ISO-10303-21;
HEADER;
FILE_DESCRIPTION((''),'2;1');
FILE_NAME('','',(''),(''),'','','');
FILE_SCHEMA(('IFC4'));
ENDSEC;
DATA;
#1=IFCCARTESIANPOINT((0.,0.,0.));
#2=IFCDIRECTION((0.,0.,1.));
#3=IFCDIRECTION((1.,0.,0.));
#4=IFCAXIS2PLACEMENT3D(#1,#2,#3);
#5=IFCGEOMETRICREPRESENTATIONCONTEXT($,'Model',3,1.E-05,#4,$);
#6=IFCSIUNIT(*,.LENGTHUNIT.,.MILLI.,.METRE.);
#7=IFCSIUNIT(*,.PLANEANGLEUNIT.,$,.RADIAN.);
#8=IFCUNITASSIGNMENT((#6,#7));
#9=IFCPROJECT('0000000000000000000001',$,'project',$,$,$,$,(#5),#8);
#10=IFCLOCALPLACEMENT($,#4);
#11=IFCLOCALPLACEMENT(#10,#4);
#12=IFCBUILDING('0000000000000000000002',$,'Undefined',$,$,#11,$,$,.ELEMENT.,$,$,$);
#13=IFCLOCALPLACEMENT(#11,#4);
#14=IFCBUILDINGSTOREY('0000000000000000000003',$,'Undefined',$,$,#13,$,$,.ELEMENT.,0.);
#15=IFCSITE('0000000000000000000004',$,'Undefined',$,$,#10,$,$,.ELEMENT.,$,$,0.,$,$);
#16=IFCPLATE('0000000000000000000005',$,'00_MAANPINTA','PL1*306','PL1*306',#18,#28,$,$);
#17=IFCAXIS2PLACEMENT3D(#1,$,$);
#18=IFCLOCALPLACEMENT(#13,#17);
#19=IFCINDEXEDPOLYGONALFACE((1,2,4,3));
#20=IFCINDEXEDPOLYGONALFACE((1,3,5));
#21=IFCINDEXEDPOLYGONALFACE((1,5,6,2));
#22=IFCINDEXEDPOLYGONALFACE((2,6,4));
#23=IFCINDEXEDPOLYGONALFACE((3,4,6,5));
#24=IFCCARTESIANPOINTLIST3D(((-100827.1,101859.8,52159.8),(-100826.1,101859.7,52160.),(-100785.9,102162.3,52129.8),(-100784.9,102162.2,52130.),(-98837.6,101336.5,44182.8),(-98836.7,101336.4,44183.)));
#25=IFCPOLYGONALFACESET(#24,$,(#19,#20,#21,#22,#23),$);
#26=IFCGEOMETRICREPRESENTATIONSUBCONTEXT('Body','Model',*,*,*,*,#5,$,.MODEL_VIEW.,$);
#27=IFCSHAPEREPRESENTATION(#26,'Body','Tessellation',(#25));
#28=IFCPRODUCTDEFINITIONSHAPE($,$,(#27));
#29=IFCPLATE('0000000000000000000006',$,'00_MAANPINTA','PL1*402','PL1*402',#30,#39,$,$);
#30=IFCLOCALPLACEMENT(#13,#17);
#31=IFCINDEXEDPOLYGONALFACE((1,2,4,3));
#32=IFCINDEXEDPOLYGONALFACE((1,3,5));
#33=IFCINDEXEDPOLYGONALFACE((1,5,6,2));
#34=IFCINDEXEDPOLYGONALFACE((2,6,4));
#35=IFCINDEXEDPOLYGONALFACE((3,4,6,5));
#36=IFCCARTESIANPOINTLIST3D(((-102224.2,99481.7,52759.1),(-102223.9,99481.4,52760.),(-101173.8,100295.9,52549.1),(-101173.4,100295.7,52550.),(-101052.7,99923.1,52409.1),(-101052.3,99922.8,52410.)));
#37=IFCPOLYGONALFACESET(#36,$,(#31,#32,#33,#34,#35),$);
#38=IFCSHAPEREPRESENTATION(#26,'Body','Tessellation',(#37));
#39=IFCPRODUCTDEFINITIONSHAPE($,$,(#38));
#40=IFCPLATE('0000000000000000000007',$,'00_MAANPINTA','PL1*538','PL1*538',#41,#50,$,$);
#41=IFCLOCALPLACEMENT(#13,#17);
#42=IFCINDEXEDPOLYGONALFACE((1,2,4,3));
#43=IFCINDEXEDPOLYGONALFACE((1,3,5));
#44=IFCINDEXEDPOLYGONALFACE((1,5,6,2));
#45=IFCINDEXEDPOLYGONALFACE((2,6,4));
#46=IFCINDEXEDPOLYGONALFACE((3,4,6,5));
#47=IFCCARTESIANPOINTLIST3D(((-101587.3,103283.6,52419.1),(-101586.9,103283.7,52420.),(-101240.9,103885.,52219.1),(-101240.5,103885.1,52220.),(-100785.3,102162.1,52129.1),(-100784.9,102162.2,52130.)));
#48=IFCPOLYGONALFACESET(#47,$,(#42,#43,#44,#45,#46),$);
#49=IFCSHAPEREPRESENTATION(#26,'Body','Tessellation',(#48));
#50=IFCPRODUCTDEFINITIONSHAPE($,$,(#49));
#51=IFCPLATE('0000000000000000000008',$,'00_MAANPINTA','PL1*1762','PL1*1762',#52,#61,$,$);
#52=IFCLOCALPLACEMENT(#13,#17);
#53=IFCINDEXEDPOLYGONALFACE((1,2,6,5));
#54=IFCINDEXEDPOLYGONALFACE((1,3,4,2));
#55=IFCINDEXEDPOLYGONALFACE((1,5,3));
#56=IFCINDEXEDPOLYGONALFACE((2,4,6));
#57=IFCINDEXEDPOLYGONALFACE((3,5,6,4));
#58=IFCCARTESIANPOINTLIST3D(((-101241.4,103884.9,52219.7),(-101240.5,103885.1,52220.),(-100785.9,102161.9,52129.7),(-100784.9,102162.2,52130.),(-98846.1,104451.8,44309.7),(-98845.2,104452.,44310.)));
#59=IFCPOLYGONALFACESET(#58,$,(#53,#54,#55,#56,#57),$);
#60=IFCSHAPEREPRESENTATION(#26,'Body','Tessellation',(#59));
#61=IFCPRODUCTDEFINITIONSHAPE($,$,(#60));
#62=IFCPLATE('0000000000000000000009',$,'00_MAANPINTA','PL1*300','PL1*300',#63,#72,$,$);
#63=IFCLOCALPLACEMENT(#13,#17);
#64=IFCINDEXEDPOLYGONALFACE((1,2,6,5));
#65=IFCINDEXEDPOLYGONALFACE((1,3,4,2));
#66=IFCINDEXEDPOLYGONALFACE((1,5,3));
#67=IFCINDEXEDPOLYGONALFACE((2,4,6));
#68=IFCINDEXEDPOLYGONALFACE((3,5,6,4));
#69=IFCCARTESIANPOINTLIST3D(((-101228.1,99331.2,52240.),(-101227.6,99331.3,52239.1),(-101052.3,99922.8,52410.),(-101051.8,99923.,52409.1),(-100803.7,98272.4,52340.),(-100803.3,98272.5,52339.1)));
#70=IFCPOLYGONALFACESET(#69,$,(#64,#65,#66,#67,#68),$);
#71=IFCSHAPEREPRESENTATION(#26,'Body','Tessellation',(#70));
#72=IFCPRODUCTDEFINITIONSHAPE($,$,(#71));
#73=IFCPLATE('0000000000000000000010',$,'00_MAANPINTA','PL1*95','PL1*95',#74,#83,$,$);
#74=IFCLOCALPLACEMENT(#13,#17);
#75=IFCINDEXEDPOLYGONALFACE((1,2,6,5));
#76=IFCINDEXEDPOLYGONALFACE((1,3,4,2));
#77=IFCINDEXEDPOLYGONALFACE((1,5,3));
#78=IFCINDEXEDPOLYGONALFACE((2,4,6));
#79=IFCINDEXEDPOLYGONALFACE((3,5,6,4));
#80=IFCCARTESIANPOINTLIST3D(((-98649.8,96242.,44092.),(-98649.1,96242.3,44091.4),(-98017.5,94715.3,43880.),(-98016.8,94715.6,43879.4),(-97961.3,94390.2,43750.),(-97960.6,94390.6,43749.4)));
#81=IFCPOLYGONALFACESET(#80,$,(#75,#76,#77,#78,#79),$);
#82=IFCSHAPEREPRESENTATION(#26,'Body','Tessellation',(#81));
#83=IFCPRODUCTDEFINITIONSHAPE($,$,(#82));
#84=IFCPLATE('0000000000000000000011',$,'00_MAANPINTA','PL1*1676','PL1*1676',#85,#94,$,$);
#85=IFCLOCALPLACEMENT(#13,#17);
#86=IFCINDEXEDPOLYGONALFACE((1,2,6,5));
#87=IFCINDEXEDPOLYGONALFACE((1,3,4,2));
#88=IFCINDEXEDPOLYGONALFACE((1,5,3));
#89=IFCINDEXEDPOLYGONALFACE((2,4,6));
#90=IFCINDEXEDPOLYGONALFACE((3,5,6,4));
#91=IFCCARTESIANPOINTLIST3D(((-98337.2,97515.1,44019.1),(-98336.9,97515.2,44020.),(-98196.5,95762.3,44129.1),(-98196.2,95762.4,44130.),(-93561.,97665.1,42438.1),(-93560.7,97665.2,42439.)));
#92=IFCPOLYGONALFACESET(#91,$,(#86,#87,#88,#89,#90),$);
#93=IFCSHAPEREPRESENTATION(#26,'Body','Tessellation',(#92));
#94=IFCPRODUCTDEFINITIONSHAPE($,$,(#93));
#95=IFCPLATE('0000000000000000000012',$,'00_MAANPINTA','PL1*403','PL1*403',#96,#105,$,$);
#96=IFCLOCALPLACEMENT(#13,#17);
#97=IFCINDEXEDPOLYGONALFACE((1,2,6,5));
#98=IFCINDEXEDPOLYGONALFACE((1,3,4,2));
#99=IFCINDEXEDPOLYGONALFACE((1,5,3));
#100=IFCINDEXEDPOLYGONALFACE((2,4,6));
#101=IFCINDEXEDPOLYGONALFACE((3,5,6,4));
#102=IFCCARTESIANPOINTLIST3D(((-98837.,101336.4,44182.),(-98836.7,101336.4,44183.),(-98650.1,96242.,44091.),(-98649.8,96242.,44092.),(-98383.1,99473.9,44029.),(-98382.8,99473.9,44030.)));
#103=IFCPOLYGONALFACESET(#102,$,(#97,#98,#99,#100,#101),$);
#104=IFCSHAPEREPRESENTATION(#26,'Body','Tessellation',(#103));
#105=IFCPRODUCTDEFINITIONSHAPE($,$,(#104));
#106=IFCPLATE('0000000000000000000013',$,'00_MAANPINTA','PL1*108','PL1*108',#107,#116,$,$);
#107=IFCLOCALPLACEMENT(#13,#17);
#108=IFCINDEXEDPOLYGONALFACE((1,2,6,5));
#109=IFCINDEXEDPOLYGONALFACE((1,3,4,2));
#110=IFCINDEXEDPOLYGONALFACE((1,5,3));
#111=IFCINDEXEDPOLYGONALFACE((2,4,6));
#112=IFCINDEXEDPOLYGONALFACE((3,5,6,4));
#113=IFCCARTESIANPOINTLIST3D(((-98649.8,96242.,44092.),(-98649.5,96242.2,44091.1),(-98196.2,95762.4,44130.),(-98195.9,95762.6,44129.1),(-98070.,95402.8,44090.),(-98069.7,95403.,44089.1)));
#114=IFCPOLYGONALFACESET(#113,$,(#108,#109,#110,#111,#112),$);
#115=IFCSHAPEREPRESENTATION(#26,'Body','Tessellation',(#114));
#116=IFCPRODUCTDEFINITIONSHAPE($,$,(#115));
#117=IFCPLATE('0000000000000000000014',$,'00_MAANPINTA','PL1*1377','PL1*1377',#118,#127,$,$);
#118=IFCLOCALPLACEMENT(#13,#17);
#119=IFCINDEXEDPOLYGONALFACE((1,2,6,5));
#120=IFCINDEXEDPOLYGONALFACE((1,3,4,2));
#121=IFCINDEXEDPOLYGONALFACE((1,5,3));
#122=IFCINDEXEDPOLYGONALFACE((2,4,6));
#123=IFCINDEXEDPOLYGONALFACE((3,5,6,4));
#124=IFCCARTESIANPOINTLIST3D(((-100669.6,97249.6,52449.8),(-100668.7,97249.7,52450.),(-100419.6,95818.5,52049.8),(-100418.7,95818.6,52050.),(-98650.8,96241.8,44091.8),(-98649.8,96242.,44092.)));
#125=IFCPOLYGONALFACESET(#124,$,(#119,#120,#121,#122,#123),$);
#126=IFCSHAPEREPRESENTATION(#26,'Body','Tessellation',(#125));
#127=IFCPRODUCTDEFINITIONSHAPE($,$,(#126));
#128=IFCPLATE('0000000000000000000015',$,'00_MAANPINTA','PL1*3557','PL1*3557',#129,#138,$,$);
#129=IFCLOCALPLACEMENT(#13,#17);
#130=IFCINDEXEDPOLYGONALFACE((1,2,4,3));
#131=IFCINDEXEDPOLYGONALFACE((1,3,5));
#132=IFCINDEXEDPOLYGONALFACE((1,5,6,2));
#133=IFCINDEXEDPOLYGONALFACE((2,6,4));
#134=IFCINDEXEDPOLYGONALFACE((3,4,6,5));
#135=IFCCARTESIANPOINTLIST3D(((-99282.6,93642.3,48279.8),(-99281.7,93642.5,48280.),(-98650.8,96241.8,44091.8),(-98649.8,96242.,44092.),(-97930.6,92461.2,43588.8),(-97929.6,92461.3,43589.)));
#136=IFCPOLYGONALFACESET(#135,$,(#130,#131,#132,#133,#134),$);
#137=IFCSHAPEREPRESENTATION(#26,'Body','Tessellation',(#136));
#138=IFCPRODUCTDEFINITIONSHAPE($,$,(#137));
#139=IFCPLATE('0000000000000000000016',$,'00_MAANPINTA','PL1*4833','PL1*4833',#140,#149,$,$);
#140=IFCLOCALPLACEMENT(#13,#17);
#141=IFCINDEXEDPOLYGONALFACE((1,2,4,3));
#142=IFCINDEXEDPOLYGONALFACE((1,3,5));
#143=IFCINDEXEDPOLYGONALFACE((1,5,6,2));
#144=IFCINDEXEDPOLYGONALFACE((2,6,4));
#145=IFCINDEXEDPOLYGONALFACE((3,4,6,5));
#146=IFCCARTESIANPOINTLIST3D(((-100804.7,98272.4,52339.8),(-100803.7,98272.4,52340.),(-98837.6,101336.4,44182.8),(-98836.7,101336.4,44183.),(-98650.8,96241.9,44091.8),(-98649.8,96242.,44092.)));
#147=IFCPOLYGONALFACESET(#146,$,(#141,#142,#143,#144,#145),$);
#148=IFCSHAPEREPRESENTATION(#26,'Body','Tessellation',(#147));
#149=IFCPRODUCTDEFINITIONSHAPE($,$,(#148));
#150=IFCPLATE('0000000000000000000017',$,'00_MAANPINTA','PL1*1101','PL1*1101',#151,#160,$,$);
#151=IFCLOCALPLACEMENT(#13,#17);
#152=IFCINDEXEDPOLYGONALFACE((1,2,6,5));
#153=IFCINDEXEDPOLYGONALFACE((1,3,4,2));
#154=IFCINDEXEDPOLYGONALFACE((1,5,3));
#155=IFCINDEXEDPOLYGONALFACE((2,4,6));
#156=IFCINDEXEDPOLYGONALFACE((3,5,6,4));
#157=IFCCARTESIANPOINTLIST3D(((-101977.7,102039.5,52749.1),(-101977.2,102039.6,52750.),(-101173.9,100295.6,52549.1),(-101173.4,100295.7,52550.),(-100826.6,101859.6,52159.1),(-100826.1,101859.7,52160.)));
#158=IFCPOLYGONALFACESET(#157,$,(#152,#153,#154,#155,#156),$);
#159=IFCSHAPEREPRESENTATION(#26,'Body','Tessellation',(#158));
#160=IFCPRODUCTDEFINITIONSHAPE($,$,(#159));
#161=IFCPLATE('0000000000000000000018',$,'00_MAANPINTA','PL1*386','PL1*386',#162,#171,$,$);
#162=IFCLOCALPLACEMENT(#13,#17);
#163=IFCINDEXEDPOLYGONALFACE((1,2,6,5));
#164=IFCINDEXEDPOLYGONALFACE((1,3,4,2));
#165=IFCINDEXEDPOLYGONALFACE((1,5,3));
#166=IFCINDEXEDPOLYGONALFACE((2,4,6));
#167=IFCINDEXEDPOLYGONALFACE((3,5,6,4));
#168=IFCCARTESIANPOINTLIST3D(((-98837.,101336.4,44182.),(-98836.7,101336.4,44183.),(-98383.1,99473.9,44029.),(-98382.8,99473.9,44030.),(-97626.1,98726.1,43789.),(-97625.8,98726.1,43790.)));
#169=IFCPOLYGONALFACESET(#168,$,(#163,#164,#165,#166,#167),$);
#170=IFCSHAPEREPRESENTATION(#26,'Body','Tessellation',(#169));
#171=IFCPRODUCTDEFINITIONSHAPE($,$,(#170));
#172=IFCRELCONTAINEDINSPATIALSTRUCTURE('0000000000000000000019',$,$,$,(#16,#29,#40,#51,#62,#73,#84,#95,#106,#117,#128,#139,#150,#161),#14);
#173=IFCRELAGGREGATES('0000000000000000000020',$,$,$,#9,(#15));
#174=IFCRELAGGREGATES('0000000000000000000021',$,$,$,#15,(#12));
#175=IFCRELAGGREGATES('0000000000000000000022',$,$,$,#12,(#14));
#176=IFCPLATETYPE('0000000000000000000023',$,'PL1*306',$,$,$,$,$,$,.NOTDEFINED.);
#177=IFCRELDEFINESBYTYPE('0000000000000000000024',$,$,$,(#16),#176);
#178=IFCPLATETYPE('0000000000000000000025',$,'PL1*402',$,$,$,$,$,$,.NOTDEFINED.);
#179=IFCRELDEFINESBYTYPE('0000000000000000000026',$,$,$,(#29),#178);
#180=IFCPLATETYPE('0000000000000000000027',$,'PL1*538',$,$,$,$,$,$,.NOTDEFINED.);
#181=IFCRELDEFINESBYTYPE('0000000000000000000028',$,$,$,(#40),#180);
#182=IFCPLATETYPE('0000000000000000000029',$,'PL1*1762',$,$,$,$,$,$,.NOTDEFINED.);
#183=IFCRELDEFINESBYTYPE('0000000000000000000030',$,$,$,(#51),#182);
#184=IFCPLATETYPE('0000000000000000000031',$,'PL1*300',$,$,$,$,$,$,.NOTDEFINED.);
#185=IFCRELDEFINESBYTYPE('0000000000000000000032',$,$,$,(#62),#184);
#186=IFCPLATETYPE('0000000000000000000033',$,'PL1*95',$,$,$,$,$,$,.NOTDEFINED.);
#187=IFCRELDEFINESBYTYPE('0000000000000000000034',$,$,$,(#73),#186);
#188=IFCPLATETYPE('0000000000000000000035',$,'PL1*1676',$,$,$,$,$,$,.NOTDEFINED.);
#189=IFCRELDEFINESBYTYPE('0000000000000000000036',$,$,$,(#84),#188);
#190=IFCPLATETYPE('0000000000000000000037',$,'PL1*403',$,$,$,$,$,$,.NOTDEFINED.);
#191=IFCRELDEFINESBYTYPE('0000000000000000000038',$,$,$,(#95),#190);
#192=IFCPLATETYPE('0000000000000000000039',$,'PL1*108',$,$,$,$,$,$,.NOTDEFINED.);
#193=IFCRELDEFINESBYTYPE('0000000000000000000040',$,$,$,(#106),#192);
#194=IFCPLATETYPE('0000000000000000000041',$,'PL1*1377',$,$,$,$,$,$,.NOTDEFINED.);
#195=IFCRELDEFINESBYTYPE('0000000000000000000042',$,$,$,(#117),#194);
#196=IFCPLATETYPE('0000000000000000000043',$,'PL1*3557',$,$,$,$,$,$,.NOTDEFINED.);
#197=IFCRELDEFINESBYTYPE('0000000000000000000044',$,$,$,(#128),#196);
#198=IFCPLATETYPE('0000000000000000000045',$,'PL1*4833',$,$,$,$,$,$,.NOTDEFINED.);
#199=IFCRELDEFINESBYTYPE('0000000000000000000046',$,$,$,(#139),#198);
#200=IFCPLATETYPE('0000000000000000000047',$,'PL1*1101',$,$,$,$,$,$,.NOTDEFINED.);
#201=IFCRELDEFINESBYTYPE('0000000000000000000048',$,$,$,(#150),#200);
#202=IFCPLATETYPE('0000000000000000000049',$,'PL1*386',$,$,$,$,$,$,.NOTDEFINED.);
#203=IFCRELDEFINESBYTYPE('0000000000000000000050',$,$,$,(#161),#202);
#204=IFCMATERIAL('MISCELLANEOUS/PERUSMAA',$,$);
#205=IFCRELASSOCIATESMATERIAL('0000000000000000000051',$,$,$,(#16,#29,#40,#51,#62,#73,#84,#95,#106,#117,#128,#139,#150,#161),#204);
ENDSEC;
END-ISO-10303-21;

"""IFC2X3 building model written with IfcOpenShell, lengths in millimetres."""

from ifc_helpers import new_model, si_unit, frame, origin_with_axes, place, context, subcontext, project, spatial, polyline, outline, extrude, material, type_object, element, save


model = new_model("IFC2X3")

# Units and contexts
model_context = context("Model", 3, precision=1e-05, world=origin_with_axes())
body_context = subcontext(model_context, "Body", "Model", "MODEL_VIEW")
ifc_project = project(units=[si_unit("LENGTHUNIT", "METRE", prefix="MILLI"), si_unit("PLANEANGLEUNIT", "RADIAN")], contexts=[model_context])

# Site, building, storey
site_placement = place(None, origin_with_axes())
site = spatial("IfcSite", under=ifc_project, at=site_placement, Name="Undefined", CompositionType="ELEMENT", RefElevation=0.0)
building_placement = place(site_placement, origin_with_axes())
building = spatial("IfcBuilding", under=site, at=building_placement, Name="Undefined", CompositionType="ELEMENT")
storey_placement = place(building_placement, origin_with_axes())
storey = spatial("IfcBuildingStorey", under=building, at=storey_placement, Name="Undefined", CompositionType="ELEMENT", Elevation=0.0)

# Plates
ifc_material = material(Name="MISCELLANEOUS/PERUSMAA")
plate_type_1 = type_object("IfcPlateType", Name="PL1*306", PredefinedType="NOTDEFINED")
plate_1_placement = place(storey_placement, frame((-100826.6, 101859.7, 52159.9), z_axis=(-0.963077, 0.106682, -0.247189), x_axis=(0.134334, 0.986098, -0.097797)))
element("IfcPlate", 1, at=plate_1_placement, inside=storey, type_object=plate_type_1, material=ifc_material, Name="00_MAANPINTA", Description="PL1*306", ObjectType="PL1*306", context=body_context, shape_type="SweptSolid", body=[
    extrude(outline(polyline([(0.0, 0.0), (306.8, 0.0), (531.4, 8220.8), (0.0, 0.0)])), frame((0.0, 0.0, -0.5), z_axis=(0.0, 0.0, 1.0), x_axis=(1.0, 0.0, 0.0)), (0.0, 0.0, 1.0), 1.0),
])
plate_type_2 = type_object("IfcPlateType", Name="PL1*402", PredefinedType="NOTDEFINED")
plate_2_placement = place(storey_placement, frame((-101173.6, 100295.8, 52549.5), z_axis=(-0.355768, 0.225022, -0.90708), x_axis=(0.290924, -0.895692, -0.336301)))
element("IfcPlate", 2, at=plate_2_placement, inside=storey, type_object=plate_type_2, material=ifc_material, Name="00_MAANPINTA", Description="PL1*402", ObjectType="PL1*402", context=body_context, shape_type="SweptSolid", body=[
    extrude(outline(polyline([(0.0, 0.0), (416.3, 0.0), (353.1, 1298.4), (0.0, 0.0)])), frame((0.0, 0.0, -0.5), z_axis=(0.0, 0.0, 1.0), x_axis=(1.0, 0.0, 0.0)), (0.0, 0.0, 1.0), 1.0),
])
plate_type_3 = type_object("IfcPlateType", Name="PL1*538", PredefinedType="NOTDEFINED")
plate_3_placement = place(storey_placement, frame((-100785.1, 102162.1, 52129.5), z_axis=(-0.415493, -0.062458, -0.907449), x_axis=(-0.569206, 0.796013, 0.205834)))
element("IfcPlate", 3, at=plate_3_placement, inside=storey, type_object=plate_type_3, material=ifc_material, Name="00_MAANPINTA", Description="PL1*538", ObjectType="PL1*538", context=body_context, shape_type="SweptSolid", body=[
    extrude(outline(polyline([(0.0, 0.0), (1408.9, 0.0), (1649.3, 681.1), (0.0, 0.0)])), frame((0.0, 0.0, -0.5), z_axis=(0.0, 0.0, 1.0), x_axis=(1.0, 0.0, 0.0)), (0.0, 0.0, 1.0), 1.0),
])
plate_type_4 = type_object("IfcPlateType", Name="PL1*1762", PredefinedType="NOTDEFINED")
plate_4_placement = place(storey_placement, frame((-100785.4, 102162.1, 52129.9), z_axis=(-0.926839, -0.229543, -0.297117), x_axis=(-0.255298, 0.965546, 0.050437)))
element("IfcPlate", 4, at=plate_4_placement, inside=storey, type_object=plate_type_4, material=ifc_material, Name="00_MAANPINTA", Description="PL1*1762", ObjectType="PL1*1762", context=body_context, shape_type="SweptSolid", body=[
    extrude(outline(polyline([(0.0, 0.0), (1784.4, 0.0), (1321.3, 8271.2), (0.0, 0.0)])), frame((0.0, 0.0, -0.5), z_axis=(0.0, 0.0, 1.0), x_axis=(1.0, 0.0, 0.0)), (0.0, 0.0, 1.0), 1.0),
])
plate_type_5 = type_object("IfcPlateType", Name="PL1*300", PredefinedType="NOTDEFINED")
plate_5_placement = place(storey_placement, frame((-100803.5, 98272.5, 52339.6), z_axis=(0.477065, 0.108838, -0.872103), x_axis=(-0.370602, 0.924677, -0.08733)))
element("IfcPlate", 5, at=plate_5_placement, inside=storey, type_object=plate_type_5, material=ifc_material, Name="00_MAANPINTA", Description="PL1*300", ObjectType="PL1*300", context=body_context, shape_type="SweptSolid", body=[
    extrude(outline(polyline([(0.0, 0.0), (1145.1, 0.0), (1612.1, 437.8), (0.0, 0.0)])), frame((0.0, 0.0, -0.5), z_axis=(0.0, 0.0, 1.0), x_axis=(1.0, 0.0, 0.0)), (0.0, 0.0, 1.0), 1.0),
])
plate_type_6 = type_object("IfcPlateType", Name="PL1*95", PredefinedType="NOTDEFINED")
plate_6_placement = place(storey_placement, frame((-98649.5, 96242.1, 44091.7), z_axis=(0.6824, 0.370155, -0.63033), x_axis=(0.379534, -0.916385, -0.127251)))
element("IfcPlate", 6, at=plate_6_placement, inside=storey, type_object=plate_type_6, material=ifc_material, Name="00_MAANPINTA", Description="PL1*95", ObjectType="PL1*95", context=body_context, shape_type="SweptSolid", body=[
    extrude(outline(polyline([(0.0, 0.0), (1666.0, 0.0), (2001.7, 114.0), (0.0, 0.0)])), frame((0.0, 0.0, -0.5), z_axis=(0.0, 0.0, 1.0), x_axis=(1.0, 0.0, 0.0)), (0.0, 0.0, 1.0), 1.0),
])
plate_type_7 = type_object("IfcPlateType", Name="PL1*1676", PredefinedType="NOTDEFINED")
plate_7_placement = place(storey_placement, frame((-98337.1, 97515.2, 44019.5), z_axis=(-0.310738, -0.084366, -0.946744), x_axis=(0.948919, 0.029808, -0.314108)))
element("IfcPlate", 7, at=plate_7_placement, inside=storey, type_object=plate_type_7, material=ifc_material, Name="00_MAANPINTA", Description="PL1*1676", ObjectType="PL1*1676", context=body_context, shape_type="SweptSolid", body=[
    extrude(outline(polyline([(0.0, 0.0), (5033.3, 0.0), (46.8, 1761.2), (0.0, 0.0)])), frame((0.0, 0.0, -0.5), z_axis=(0.0, 0.0, 1.0), x_axis=(1.0, 0.0, 0.0)), (0.0, 0.0, 1.0), 1.0),
])
plate_type_8 = type_object("IfcPlateType", Name="PL1*403", PredefinedType="NOTDEFINED")
plate_8_placement = place(storey_placement, frame((-98650.0, 96242.0, 44091.5), z_axis=(-0.296576, 0.00618, -0.954989), x_axis=(-0.036651, 0.999169, 0.017848)))
element("IfcPlate", 8, at=plate_8_placement, inside=storey, type_object=plate_type_8, material=ifc_material, Name="00_MAANPINTA", Description="PL1*403", ObjectType="PL1*403", context=body_context, shape_type="SweptSolid", body=[
    extrude(outline(polyline([(0.0, 0.0), (5098.7, 0.0), (3218.4, 403.4), (0.0, 0.0)])), frame((0.0, 0.0, -0.5), z_axis=(0.0, 0.0, 1.0), x_axis=(1.0, 0.0, 0.0)), (0.0, 0.0, 1.0), 1.0),
])
plate_type_9 = type_object("IfcPlateType", Name="PL1*108", PredefinedType="NOTDEFINED")
plate_9_placement = place(storey_placement, frame((-98649.7, 96242.1, 44091.5), z_axis=(0.29813, 0.20821, -0.93154), x_axis=(0.686084, -0.725249, 0.057472)))
element("IfcPlate", 9, at=plate_9_placement, inside=storey, type_object=plate_type_9, material=ifc_material, Name="00_MAANPINTA", Description="PL1*108", ObjectType="PL1*108", context=body_context, shape_type="SweptSolid", body=[
    extrude(outline(polyline([(0.0, 0.0), (661.2, 0.0), (1006.3, 166.6), (0.0, 0.0)])), frame((0.0, 0.0, -0.5), z_axis=(0.0, 0.0, 1.0), x_axis=(1.0, 0.0, 0.0)), (0.0, 0.0, 1.0), 1.0),
])
plate_type_10 = type_object("IfcPlateType", Name="PL1*1377", PredefinedType="NOTDEFINED")
plate_10_placement = place(storey_placement, frame((-100669.2, 97249.6, 52449.9), z_axis=(-0.969291, -0.107515, -0.221168), x_axis=(0.2332, -0.116404, -0.965436)))
element("IfcPlate", 10, at=plate_10_placement, inside=storey, type_object=plate_type_10, material=ifc_material, Name="00_MAANPINTA", Description="PL1*1377", ObjectType="PL1*1377", context=body_context, shape_type="SweptSolid", body=[
    extrude(outline(polyline([(0.0, 0.0), (8657.2, 0.0), (611.1, 1377.4), (0.0, 0.0)])), frame((0.0, 0.0, -0.5), z_axis=(0.0, 0.0, 1.0), x_axis=(1.0, 0.0, 0.0)), (0.0, 0.0, 1.0), 1.0),
])
plate_type_11 = type_object("IfcPlateType", Name="PL1*3557", PredefinedType="NOTDEFINED")
plate_11_placement = place(storey_placement, frame((-98650.3, 96241.9, 44091.9), z_axis=(-0.959335, -0.151016, -0.238477), x_axis=(0.185548, -0.974052, -0.129594)))
element("IfcPlate", 11, at=plate_11_placement, inside=storey, type_object=plate_type_11, material=ifc_material, Name="00_MAANPINTA", Description="PL1*3557", ObjectType="PL1*3557", context=body_context, shape_type="SweptSolid", body=[
    extrude(outline(polyline([(0.0, 0.0), (3881.4, 0.0), (1872.0, 4603.4), (0.0, 0.0)])), frame((0.0, 0.0, -0.5), z_axis=(0.0, 0.0, 1.0), x_axis=(1.0, 0.0, 0.0)), (0.0, 0.0, 1.0), 1.0),
])
plate_type_12 = type_object("IfcPlateType", Name="PL1*4833", PredefinedType="NOTDEFINED")
plate_12_placement = place(storey_placement, frame((-98837.2, 101336.4, 44182.9), z_axis=(-0.968931, -0.031159, -0.245362), x_axis=(0.036651, -0.999169, -0.017848)))
element("IfcPlate", 12, at=plate_12_placement, inside=storey, type_object=plate_type_12, material=ifc_material, Name="00_MAANPINTA", Description="PL1*4833", ObjectType="PL1*4833", context=body_context, shape_type="SweptSolid", body=[
    extrude(outline(polyline([(0.0, 0.0), (5098.7, 0.0), (2843.8, 8468.0), (0.0, 0.0)])), frame((0.0, 0.0, -0.5), z_axis=(0.0, 0.0, 1.0), x_axis=(1.0, 0.0, 0.0)), (0.0, 0.0, 1.0), 1.0),
])
plate_type_13 = type_object("IfcPlateType", Name="PL1*1101", PredefinedType="NOTDEFINED")
plate_13_placement = place(storey_placement, frame((-101173.6, 100295.7, 52549.6), z_axis=(-0.467285, -0.114839, -0.876617), x_axis=(-0.416331, 0.903292, 0.103594)))
element("IfcPlate", 13, at=plate_13_placement, inside=storey, type_object=plate_type_13, material=ifc_material, Name="00_MAANPINTA", Description="PL1*1101", ObjectType="PL1*1101", context=body_context, shape_type="SweptSolid", body=[
    extrude(outline(polyline([(0.0, 0.0), (1930.6, 0.0), (1227.7, 1100.6), (0.0, 0.0)])), frame((0.0, 0.0, -0.5), z_axis=(0.0, 0.0, 1.0), x_axis=(1.0, 0.0, 0.0)), (0.0, 0.0, 1.0), 1.0),
])
plate_type_14 = type_object("IfcPlateType", Name="PL1*386", PredefinedType="NOTDEFINED")
plate_14_placement = place(storey_placement, frame((-97626.0, 98726.1, 43789.5), z_axis=(-0.296686, 0.00615, -0.954955), x_axis=(-0.693996, 0.685535, 0.220026)))
element("IfcPlate", 14, at=plate_14_placement, inside=storey, type_object=plate_type_14, material=ifc_material, Name="00_MAANPINTA", Description="PL1*386", ObjectType="PL1*386", context=body_context, shape_type="SweptSolid", body=[
    extrude(outline(polyline([(0.0, 0.0), (1090.8, 0.0), (2716.2, 1027.7), (0.0, 0.0)])), frame((0.0, 0.0, -0.5), z_axis=(0.0, 0.0, 1.0), x_axis=(1.0, 0.0, 0.0)), (0.0, 0.0, 1.0), 1.0),
])

save(model, "model.ifc")
